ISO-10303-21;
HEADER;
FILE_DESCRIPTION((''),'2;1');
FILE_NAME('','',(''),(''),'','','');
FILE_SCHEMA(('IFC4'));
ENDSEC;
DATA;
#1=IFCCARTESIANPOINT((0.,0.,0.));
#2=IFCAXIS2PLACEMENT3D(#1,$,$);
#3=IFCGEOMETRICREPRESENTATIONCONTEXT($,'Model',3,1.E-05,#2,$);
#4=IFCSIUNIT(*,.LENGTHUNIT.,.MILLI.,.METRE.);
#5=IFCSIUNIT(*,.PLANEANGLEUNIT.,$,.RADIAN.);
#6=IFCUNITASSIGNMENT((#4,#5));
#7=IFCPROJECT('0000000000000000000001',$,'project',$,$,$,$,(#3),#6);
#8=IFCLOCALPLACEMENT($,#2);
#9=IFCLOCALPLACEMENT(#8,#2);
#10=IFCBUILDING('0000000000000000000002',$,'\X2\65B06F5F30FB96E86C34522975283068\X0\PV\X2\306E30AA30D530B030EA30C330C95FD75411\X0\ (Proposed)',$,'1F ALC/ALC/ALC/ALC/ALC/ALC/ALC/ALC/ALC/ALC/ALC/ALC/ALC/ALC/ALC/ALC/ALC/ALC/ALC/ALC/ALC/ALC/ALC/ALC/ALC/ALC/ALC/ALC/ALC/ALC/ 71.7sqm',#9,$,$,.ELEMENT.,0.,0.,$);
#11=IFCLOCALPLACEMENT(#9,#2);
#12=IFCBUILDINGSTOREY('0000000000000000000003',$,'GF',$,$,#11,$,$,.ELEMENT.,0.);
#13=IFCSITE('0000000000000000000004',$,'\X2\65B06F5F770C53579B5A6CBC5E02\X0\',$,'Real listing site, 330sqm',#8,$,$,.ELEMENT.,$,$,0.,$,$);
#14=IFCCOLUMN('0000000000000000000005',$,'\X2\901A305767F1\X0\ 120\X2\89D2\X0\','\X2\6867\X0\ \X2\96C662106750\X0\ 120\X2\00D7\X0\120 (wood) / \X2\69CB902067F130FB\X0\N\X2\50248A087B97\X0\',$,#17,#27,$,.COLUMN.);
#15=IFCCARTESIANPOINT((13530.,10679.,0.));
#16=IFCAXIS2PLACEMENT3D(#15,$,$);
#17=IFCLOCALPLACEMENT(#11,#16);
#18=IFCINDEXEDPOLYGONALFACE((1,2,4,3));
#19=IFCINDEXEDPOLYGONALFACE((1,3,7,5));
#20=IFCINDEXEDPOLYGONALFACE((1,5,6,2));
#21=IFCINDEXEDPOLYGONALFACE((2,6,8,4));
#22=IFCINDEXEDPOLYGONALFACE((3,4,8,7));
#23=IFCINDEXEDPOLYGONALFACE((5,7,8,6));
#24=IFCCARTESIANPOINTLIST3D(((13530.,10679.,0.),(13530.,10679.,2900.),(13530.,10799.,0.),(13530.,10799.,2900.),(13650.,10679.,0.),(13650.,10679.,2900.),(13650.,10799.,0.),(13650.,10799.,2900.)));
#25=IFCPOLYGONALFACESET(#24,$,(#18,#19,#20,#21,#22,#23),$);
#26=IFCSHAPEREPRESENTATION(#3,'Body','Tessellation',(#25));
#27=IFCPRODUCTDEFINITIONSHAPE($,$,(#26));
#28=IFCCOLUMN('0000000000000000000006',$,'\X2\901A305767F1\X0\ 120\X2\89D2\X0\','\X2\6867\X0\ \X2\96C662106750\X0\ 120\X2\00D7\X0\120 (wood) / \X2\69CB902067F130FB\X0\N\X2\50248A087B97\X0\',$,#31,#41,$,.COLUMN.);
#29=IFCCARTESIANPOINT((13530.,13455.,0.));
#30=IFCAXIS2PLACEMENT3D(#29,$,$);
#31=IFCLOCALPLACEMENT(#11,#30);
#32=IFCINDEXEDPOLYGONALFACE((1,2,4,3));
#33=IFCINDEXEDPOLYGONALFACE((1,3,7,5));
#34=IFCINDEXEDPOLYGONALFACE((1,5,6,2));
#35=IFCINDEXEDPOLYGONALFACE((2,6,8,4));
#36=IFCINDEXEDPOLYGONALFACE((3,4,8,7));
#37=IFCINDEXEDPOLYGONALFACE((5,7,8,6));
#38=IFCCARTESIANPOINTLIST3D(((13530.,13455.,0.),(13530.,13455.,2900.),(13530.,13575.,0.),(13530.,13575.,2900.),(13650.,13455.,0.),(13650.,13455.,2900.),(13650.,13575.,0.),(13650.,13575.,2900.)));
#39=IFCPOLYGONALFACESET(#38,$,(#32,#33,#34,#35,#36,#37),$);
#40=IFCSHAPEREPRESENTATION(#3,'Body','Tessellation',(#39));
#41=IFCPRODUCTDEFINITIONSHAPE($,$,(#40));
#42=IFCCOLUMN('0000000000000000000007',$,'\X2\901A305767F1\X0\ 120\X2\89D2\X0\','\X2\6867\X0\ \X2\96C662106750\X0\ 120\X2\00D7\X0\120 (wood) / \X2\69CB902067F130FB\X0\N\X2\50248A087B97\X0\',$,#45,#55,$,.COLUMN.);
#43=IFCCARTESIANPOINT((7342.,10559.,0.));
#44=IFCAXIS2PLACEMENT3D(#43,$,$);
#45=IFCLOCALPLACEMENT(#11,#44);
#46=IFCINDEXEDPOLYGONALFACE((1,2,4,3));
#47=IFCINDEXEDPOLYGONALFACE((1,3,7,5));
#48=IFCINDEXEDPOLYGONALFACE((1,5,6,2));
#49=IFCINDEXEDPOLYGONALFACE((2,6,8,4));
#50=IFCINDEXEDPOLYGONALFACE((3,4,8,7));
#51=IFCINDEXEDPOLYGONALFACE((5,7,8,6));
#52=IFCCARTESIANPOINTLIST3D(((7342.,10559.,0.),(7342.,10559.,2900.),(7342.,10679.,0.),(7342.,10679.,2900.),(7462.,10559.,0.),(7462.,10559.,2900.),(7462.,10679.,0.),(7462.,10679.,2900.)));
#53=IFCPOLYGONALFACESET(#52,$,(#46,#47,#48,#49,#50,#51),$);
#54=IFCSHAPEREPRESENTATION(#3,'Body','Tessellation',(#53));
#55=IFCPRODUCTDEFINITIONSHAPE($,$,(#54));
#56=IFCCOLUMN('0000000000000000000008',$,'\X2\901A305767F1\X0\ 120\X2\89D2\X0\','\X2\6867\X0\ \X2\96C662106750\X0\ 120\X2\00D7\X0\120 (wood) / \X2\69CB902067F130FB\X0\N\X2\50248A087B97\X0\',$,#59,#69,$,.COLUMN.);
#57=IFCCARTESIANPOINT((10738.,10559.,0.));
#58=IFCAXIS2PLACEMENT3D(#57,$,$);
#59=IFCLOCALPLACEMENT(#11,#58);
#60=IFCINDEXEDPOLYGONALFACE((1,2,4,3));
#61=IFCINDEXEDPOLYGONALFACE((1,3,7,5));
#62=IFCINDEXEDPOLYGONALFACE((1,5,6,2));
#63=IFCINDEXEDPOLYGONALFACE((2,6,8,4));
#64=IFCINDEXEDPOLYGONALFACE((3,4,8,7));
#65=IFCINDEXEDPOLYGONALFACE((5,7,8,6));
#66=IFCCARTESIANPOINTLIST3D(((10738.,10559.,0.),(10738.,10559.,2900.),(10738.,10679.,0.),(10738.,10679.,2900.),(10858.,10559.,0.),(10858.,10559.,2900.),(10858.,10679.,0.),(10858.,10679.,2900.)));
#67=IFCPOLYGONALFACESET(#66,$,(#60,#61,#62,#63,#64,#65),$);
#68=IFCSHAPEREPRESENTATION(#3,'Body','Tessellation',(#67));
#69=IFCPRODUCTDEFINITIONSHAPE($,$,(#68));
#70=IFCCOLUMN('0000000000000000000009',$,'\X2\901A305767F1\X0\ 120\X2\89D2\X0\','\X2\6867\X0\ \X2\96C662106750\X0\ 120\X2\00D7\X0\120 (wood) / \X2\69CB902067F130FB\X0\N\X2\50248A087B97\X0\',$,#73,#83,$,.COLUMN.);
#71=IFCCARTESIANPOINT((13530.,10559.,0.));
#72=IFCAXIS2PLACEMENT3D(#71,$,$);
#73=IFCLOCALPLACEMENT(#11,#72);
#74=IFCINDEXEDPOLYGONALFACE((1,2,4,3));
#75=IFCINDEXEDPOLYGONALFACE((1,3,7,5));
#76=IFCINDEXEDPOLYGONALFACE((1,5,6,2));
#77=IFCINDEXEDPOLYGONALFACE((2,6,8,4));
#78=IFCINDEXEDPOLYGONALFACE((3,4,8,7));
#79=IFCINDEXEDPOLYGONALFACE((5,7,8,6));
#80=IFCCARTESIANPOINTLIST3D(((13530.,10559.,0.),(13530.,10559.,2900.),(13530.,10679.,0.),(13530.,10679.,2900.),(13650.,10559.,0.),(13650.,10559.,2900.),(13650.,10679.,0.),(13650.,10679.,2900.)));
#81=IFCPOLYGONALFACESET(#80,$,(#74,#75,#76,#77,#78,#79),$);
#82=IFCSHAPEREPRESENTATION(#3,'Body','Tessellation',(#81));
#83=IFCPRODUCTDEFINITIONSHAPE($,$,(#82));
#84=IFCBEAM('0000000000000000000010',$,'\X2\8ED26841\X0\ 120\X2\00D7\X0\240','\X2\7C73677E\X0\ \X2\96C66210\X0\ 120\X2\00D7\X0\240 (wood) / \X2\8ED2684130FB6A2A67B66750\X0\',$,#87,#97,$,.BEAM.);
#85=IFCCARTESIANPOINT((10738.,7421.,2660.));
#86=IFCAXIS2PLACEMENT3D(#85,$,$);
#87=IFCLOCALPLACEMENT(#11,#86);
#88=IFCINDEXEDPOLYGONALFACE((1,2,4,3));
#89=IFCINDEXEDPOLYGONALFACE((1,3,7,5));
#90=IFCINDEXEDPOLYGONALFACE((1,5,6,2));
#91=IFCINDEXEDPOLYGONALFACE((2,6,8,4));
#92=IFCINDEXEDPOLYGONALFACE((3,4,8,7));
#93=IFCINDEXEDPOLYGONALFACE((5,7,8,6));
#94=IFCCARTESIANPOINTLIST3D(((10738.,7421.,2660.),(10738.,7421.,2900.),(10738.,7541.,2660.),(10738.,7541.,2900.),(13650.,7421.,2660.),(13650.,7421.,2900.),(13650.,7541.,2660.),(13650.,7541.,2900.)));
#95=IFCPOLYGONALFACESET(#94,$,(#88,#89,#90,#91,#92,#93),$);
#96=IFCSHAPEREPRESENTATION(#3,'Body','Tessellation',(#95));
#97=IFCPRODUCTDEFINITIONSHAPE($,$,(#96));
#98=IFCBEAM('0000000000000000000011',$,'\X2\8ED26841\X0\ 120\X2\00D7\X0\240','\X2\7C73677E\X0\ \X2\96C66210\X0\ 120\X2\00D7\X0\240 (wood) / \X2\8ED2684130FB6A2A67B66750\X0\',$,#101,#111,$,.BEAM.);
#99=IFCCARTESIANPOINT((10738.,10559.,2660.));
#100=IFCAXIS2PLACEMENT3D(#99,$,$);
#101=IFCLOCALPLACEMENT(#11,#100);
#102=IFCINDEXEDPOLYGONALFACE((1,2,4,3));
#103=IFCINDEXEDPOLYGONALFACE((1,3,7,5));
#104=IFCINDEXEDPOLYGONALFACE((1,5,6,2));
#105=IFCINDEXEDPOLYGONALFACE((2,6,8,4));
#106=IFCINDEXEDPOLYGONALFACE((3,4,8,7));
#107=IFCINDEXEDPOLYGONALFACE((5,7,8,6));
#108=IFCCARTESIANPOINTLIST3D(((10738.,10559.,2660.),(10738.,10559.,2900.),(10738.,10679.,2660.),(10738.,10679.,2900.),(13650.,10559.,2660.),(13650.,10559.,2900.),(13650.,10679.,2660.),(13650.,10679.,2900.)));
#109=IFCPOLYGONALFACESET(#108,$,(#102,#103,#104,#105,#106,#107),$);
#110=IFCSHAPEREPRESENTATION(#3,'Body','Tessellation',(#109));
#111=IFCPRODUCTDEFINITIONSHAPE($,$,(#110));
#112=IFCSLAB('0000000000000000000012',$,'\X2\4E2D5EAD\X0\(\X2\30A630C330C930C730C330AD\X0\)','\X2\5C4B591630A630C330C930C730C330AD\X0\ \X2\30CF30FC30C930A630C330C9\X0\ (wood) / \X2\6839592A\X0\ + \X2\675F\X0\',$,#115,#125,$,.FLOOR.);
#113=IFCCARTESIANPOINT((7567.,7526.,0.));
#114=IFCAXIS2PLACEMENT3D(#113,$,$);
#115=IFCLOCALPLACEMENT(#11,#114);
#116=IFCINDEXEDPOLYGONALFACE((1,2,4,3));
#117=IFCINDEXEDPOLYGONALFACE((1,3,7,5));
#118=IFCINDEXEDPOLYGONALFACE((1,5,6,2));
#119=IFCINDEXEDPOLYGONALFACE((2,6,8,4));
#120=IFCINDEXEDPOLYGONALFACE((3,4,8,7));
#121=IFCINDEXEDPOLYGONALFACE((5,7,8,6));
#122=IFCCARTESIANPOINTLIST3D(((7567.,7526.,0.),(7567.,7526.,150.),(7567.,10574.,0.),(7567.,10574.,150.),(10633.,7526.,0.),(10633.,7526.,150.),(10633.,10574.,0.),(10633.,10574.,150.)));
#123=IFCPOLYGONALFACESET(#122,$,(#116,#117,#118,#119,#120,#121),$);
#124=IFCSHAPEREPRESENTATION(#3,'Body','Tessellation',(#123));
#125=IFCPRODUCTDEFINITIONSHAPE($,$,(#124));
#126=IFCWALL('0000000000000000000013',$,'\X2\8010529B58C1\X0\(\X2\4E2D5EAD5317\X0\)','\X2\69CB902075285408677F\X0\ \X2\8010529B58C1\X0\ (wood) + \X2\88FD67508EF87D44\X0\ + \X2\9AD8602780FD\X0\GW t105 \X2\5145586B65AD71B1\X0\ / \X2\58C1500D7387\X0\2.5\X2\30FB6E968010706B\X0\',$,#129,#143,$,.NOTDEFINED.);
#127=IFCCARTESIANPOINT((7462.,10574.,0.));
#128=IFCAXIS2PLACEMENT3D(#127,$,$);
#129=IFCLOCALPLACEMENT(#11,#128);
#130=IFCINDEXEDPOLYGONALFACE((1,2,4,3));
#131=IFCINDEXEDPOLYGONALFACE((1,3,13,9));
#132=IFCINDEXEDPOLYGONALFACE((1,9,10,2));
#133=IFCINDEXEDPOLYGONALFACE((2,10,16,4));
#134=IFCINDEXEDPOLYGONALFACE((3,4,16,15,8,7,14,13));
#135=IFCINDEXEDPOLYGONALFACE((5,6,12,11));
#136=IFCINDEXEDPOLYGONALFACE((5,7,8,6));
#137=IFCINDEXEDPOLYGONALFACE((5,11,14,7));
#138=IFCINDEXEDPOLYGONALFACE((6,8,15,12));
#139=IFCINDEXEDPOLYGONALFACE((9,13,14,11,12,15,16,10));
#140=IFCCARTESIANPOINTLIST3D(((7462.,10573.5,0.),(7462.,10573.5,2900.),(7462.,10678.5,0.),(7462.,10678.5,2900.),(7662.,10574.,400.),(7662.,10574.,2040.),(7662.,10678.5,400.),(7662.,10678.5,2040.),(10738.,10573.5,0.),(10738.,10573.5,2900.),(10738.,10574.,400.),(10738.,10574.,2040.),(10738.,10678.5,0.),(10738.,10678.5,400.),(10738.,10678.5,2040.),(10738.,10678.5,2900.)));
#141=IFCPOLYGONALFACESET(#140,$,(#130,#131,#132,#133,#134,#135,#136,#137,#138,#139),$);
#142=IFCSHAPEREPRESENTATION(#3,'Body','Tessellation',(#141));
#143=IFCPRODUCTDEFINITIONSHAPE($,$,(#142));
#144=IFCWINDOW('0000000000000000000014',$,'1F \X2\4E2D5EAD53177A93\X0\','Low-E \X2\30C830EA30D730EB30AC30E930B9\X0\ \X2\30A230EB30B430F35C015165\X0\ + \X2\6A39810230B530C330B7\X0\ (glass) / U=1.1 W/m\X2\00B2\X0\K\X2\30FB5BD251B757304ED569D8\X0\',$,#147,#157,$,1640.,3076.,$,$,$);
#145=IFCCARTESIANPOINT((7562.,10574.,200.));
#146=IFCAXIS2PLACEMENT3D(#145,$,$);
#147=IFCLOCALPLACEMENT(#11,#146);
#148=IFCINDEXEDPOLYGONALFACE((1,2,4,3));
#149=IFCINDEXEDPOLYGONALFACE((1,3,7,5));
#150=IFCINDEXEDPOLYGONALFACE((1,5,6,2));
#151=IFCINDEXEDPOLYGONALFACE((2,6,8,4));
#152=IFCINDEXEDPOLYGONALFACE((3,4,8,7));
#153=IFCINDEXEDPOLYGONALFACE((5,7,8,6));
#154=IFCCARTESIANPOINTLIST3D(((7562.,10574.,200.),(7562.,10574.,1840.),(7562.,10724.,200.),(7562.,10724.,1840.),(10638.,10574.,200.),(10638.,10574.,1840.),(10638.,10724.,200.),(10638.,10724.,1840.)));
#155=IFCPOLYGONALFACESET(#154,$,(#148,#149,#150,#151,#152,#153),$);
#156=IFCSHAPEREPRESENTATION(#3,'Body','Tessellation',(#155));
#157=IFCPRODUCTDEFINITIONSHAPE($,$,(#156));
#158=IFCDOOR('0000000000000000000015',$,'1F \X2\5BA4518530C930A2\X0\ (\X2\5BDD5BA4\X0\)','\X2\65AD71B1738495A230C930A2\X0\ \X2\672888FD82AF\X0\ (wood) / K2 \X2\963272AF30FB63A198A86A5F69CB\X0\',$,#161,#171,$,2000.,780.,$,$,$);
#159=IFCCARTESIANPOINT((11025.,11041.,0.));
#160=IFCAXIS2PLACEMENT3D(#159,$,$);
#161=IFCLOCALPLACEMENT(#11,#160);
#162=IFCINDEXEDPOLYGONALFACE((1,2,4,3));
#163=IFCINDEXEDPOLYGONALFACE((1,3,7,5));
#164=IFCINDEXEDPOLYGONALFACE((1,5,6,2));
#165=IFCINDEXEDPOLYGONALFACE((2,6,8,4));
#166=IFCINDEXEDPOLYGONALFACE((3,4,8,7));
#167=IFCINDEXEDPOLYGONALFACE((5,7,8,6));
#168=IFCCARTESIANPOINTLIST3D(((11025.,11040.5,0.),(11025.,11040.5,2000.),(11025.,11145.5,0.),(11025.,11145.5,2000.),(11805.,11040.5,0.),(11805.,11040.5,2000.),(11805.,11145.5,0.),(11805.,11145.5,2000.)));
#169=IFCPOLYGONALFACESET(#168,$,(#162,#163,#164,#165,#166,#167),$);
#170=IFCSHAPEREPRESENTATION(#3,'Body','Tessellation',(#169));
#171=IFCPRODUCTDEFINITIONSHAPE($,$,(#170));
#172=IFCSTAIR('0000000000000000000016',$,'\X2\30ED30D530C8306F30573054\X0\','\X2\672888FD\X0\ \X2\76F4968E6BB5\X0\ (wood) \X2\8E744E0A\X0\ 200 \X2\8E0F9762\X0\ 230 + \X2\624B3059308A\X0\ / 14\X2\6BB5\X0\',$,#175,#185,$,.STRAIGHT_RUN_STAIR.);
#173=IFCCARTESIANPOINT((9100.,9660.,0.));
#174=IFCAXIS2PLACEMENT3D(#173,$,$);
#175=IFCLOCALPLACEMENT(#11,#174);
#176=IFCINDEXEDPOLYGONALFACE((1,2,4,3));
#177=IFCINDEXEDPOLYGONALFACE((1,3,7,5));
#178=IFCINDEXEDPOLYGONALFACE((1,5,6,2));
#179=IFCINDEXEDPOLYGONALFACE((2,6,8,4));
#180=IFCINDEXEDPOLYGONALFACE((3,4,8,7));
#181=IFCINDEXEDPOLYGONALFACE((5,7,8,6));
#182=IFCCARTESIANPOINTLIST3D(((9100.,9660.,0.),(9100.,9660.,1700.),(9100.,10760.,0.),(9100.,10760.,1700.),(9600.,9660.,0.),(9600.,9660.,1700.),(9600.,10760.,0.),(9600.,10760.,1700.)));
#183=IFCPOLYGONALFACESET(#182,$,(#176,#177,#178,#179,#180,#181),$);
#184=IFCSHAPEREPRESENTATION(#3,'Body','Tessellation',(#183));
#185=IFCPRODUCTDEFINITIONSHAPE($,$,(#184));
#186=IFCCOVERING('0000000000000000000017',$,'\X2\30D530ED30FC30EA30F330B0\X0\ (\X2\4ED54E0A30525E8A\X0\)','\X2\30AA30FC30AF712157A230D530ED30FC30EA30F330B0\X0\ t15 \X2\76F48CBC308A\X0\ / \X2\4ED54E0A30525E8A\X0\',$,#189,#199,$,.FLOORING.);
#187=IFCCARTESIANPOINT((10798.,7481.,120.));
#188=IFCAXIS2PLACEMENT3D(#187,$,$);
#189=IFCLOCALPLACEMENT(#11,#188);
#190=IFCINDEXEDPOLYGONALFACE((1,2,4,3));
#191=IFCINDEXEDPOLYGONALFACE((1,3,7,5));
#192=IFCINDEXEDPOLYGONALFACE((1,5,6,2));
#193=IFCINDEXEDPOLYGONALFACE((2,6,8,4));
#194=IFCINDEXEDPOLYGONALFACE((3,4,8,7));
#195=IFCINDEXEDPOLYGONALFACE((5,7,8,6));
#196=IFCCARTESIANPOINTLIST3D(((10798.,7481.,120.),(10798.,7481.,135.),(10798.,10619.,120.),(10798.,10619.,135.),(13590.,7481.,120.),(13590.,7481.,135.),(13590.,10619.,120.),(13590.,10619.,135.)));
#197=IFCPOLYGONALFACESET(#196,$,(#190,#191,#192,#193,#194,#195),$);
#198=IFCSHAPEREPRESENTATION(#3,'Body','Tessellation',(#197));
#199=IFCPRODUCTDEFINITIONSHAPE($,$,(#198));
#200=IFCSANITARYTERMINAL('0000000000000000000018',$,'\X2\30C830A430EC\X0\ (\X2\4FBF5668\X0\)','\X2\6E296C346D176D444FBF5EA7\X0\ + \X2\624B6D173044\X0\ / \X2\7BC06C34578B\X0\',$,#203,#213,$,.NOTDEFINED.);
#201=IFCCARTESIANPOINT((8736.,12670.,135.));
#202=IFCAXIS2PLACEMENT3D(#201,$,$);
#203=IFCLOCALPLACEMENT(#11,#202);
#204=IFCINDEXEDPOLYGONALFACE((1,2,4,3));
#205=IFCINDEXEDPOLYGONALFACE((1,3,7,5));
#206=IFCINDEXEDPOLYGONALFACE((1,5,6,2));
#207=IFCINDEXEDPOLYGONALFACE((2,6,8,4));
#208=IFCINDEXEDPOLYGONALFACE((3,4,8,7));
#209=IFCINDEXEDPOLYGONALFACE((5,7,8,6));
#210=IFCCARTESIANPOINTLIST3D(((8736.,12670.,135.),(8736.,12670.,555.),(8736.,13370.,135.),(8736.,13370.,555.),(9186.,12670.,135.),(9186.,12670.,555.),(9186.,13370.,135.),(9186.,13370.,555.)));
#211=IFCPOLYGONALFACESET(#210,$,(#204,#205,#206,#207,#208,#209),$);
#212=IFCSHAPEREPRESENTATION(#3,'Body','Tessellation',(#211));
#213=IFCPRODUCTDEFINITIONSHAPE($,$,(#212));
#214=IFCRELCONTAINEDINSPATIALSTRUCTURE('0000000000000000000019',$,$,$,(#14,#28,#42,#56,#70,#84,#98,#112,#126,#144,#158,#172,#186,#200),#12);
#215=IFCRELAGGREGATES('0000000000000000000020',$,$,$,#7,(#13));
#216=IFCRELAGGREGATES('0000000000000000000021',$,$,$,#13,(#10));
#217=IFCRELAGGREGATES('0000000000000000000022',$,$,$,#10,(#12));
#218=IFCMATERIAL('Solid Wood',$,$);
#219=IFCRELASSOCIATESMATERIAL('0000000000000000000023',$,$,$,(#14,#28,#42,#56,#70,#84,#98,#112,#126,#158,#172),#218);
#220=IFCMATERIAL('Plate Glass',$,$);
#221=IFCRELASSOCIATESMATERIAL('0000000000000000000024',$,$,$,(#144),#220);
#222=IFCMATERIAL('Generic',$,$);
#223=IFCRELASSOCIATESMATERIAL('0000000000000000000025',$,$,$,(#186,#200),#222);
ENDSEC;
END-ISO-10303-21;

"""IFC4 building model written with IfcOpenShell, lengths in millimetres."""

from ifc_helpers import new_model, si_unit, frame, frame_2d, origin, place, context, project, spatial, rectangle, extrude, material, element, fill, save


model = new_model("IFC4")

# Units and contexts
model_context = context("Model", 3, precision=1e-05, world=origin())
ifc_project = project(units=[si_unit("LENGTHUNIT", "METRE", prefix="MILLI"), si_unit("PLANEANGLEUNIT", "RADIAN")], contexts=[model_context])

# Site, building, storey
site_placement = place(None, origin())
site = spatial("IfcSite", under=ifc_project, at=site_placement, Name="新潟県南魚沼市", ObjectType="Real listing site, 330sqm", CompositionType="ELEMENT", RefElevation=0.0)
building_placement = place(site_placement, origin())
building = spatial("IfcBuilding", under=site, at=building_placement, Name="新潟・雨水利用とPVのオフグリッド志向 (Proposed)", ObjectType="1F ALC/ALC/ALC/ALC/ALC/ALC/ALC/ALC/ALC/ALC/ALC/ALC/ALC/ALC/ALC/ALC/ALC/ALC/ALC/ALC/ALC/ALC/ALC/ALC/ALC/ALC/ALC/ALC/ALC/ALC/ 71.7sqm", CompositionType="ELEMENT", ElevationOfRefHeight=0.0, ElevationOfTerrain=0.0)
storey_placement = place(building_placement, origin())
storey = spatial("IfcBuildingStorey", under=building, at=storey_placement, Name="GF", CompositionType="ELEMENT", Elevation=0.0)

# Columns
ifc_material_1 = material(Name="Solid Wood")
column_1_placement = place(storey_placement, frame((13530.0, 10679.0, 0.0)))
element("IfcColumn", 1, at=column_1_placement, inside=storey, material=ifc_material_1, Name="通し柱 120角", Description="桧 集成材 120×120 (wood) / 構造柱・N値計算", PredefinedType="COLUMN", context=model_context, shape_type="SweptSolid", body=[
    extrude(rectangle(XDim=120.0, YDim=120.0, at=frame_2d((60.0, 60.0))), frame((13530.0, 10679.0, 0.0)), (0.0, 0.0, 1.0), 2900.0),
])
column_2_placement = place(storey_placement, frame((13530.0, 13455.0, 0.0)))
element("IfcColumn", 2, at=column_2_placement, inside=storey, material=ifc_material_1, Name="通し柱 120角", Description="桧 集成材 120×120 (wood) / 構造柱・N値計算", PredefinedType="COLUMN", context=model_context, shape_type="SweptSolid", body=[
    extrude(rectangle(XDim=120.0, YDim=120.0, at=frame_2d((60.0, 60.0))), frame((13530.0, 13455.0, 0.0)), (0.0, 0.0, 1.0), 2900.0),
])
column_3_placement = place(storey_placement, frame((7342.0, 10559.0, 0.0)))
element("IfcColumn", 3, at=column_3_placement, inside=storey, material=ifc_material_1, Name="通し柱 120角", Description="桧 集成材 120×120 (wood) / 構造柱・N値計算", PredefinedType="COLUMN", context=model_context, shape_type="SweptSolid", body=[
    extrude(rectangle(XDim=120.0, YDim=120.0, at=frame_2d((60.0, 60.0))), frame((7342.0, 10559.0, 0.0)), (0.0, 0.0, 1.0), 2900.0),
])
column_4_placement = place(storey_placement, frame((10738.0, 10559.0, 0.0)))
element("IfcColumn", 4, at=column_4_placement, inside=storey, material=ifc_material_1, Name="通し柱 120角", Description="桧 集成材 120×120 (wood) / 構造柱・N値計算", PredefinedType="COLUMN", context=model_context, shape_type="SweptSolid", body=[
    extrude(rectangle(XDim=120.0, YDim=120.0, at=frame_2d((60.0, 60.0))), frame((10738.0, 10559.0, 0.0)), (0.0, 0.0, 1.0), 2900.0),
])
column_5_placement = place(storey_placement, frame((13530.0, 10559.0, 0.0)))
element("IfcColumn", 5, at=column_5_placement, inside=storey, material=ifc_material_1, Name="通し柱 120角", Description="桧 集成材 120×120 (wood) / 構造柱・N値計算", PredefinedType="COLUMN", context=model_context, shape_type="SweptSolid", body=[
    extrude(rectangle(XDim=120.0, YDim=120.0, at=frame_2d((60.0, 60.0))), frame((13530.0, 10559.0, 0.0)), (0.0, 0.0, 1.0), 2900.0),
])

# Beams
beam_1_placement = place(storey_placement, frame((10738.0, 7421.0, 2660.0)))
element("IfcBeam", 6, at=beam_1_placement, inside=storey, material=ifc_material_1, Name="軒桁 120×240", Description="米松 集成 120×240 (wood) / 軒桁・横架材", PredefinedType="BEAM", context=model_context, shape_type="SweptSolid", body=[
    extrude(rectangle(XDim=2912.0, YDim=120.0, at=frame_2d((1456.0, 60.0))), frame((10738.0, 7421.0, 2660.0)), (0.0, 0.0, 1.0), 240.0),
])
beam_2_placement = place(storey_placement, frame((10738.0, 10559.0, 2660.0)))
element("IfcBeam", 7, at=beam_2_placement, inside=storey, material=ifc_material_1, Name="軒桁 120×240", Description="米松 集成 120×240 (wood) / 軒桁・横架材", PredefinedType="BEAM", context=model_context, shape_type="SweptSolid", body=[
    extrude(rectangle(XDim=2912.0, YDim=120.0, at=frame_2d((1456.0, 60.0))), frame((10738.0, 10559.0, 2660.0)), (0.0, 0.0, 1.0), 240.0),
])

# Slab
slab_placement = place(storey_placement, frame((7567.0, 7526.0, 0.0)))
element("IfcSlab", 8, at=slab_placement, inside=storey, material=ifc_material_1, Name="中庭(ウッドデッキ)", Description="屋外ウッドデッキ ハードウッド (wood) / 根太 + 束", PredefinedType="FLOOR", context=model_context, shape_type="SweptSolid", body=[
    extrude(rectangle(XDim=3066.0, YDim=3048.0, at=frame_2d((1533.0, 1524.0))), frame((7567.0, 7526.0, 0.0)), (0.0, 0.0, 1.0), 150.0),
])

# Wall, opening, window
wall_1_placement = place(storey_placement, frame((7462.0, 10574.0, 0.0)))
wall_1 = element("IfcWall", 9, at=wall_1_placement, inside=storey, material=ifc_material_1, Name="耐力壁(中庭北)", Description="構造用合板 耐力壁 (wood) + 製材軸組 + 高性能GW t105 充填断熱 / 壁倍率2.5・準耐火", PredefinedType="NOTDEFINED", context=model_context, shape_type="SweptSolid", body=[
    extrude(rectangle(XDim=3276.0, YDim=105.0, at=frame_2d((1638.0, 52.0))), frame((7462.0, 10574.0, 0.0)), (0.0, 0.0, 1.0), 2900.0),
])
opening_placement = place(storey_placement, frame((7562.0, 10574.0, 200.0)))
opening = element("IfcOpeningElement", 10, at=opening_placement, cuts=wall_1, PredefinedType="NOTDEFINED", context=model_context, shape_type="SweptSolid", body=[
    extrude(rectangle(XDim=3076.0, YDim=150.0, at=frame_2d((1538.0, 75.0))), frame((7562.0, 10574.0, 200.0)), (0.0, 0.0, 1.0), 1640.0),
])
ifc_material_2 = material(Name="Plate Glass")
window_placement = place(storey_placement, frame((7562.0, 10574.0, 200.0)))
window = element("IfcWindow", 11, at=window_placement, inside=storey, material=ifc_material_2, Name="1F 中庭北窓", Description="Low-E トリプルガラス アルゴン封入 + 樹脂サッシ (glass) / U=1.1 W/m²K・寒冷地仕様", OverallHeight=1640.0, OverallWidth=3076.0, context=model_context, shape_type="SweptSolid", body=[
    extrude(rectangle(XDim=3076.0, YDim=150.0, at=frame_2d((1538.0, 75.0))), frame((7562.0, 10574.0, 200.0)), (0.0, 0.0, 1.0), 1640.0),
])
fill(opening, window)

# Door
door_placement = place(storey_placement, frame((11025.0, 11041.0, 0.0)))
element("IfcDoor", 12, at=door_placement, inside=storey, material=ifc_material_1, Name="1F 室内ドア (寝室)", Description="断熱玄関ドア 木製芯 (wood) / K2 防犯・採風機構", OverallHeight=2000.0, OverallWidth=780.0, context=model_context, shape_type="SweptSolid", body=[
    extrude(rectangle(XDim=780.0, YDim=105.0, at=frame_2d((390.0, 52.0))), frame((11025.0, 11041.0, 0.0)), (0.0, 0.0, 1.0), 2000.0),
])

# Stair
stair_placement = place(storey_placement, frame((9100.0, 9660.0, 0.0)))
element("IfcStair", 13, at=stair_placement, inside=storey, material=ifc_material_1, Name="ロフトはしご", Description="木製 直階段 (wood) 蹴上 200 踏面 230 + 手すり / 14段", PredefinedType="STRAIGHT_RUN_STAIR", context=model_context, shape_type="SweptSolid", body=[
    extrude(rectangle(XDim=500.0, YDim=1100.0, at=frame_2d((250.0, 550.0))), frame((9100.0, 9660.0, 0.0)), (0.0, 0.0, 1.0), 1700.0),
])

# Covering
ifc_material_3 = material(Name="Generic")
covering_placement = place(storey_placement, frame((10798.0, 7481.0, 120.0)))
element("IfcCovering", 14, at=covering_placement, inside=storey, material=ifc_material_3, Name="フローリング (仕上げ床)", Description="オーク無垢フローリング t15 直貼り / 仕上げ床", PredefinedType="FLOORING", context=model_context, shape_type="SweptSolid", body=[
    extrude(rectangle(XDim=2792.0, YDim=3138.0, at=frame_2d((1396.0, 1569.0))), frame((10798.0, 7481.0, 120.0)), (0.0, 0.0, 1.0), 15.0),
])

# Sanitary terminal
sanitary_terminal_placement = place(storey_placement, frame((8736.0, 12670.0, 135.0)))
element("IfcSanitaryTerminal", 15, at=sanitary_terminal_placement, inside=storey, material=ifc_material_3, Name="トイレ (便器)", Description="温水洗浄便座 + 手洗い / 節水型", PredefinedType="NOTDEFINED", context=model_context, shape_type="SweptSolid", body=[
    extrude(rectangle(XDim=450.0, YDim=700.0, at=frame_2d((225.0, 350.0))), frame((8736.0, 12670.0, 135.0)), (0.0, 0.0, 1.0), 420.0),
])

save(model, "model.ifc")
